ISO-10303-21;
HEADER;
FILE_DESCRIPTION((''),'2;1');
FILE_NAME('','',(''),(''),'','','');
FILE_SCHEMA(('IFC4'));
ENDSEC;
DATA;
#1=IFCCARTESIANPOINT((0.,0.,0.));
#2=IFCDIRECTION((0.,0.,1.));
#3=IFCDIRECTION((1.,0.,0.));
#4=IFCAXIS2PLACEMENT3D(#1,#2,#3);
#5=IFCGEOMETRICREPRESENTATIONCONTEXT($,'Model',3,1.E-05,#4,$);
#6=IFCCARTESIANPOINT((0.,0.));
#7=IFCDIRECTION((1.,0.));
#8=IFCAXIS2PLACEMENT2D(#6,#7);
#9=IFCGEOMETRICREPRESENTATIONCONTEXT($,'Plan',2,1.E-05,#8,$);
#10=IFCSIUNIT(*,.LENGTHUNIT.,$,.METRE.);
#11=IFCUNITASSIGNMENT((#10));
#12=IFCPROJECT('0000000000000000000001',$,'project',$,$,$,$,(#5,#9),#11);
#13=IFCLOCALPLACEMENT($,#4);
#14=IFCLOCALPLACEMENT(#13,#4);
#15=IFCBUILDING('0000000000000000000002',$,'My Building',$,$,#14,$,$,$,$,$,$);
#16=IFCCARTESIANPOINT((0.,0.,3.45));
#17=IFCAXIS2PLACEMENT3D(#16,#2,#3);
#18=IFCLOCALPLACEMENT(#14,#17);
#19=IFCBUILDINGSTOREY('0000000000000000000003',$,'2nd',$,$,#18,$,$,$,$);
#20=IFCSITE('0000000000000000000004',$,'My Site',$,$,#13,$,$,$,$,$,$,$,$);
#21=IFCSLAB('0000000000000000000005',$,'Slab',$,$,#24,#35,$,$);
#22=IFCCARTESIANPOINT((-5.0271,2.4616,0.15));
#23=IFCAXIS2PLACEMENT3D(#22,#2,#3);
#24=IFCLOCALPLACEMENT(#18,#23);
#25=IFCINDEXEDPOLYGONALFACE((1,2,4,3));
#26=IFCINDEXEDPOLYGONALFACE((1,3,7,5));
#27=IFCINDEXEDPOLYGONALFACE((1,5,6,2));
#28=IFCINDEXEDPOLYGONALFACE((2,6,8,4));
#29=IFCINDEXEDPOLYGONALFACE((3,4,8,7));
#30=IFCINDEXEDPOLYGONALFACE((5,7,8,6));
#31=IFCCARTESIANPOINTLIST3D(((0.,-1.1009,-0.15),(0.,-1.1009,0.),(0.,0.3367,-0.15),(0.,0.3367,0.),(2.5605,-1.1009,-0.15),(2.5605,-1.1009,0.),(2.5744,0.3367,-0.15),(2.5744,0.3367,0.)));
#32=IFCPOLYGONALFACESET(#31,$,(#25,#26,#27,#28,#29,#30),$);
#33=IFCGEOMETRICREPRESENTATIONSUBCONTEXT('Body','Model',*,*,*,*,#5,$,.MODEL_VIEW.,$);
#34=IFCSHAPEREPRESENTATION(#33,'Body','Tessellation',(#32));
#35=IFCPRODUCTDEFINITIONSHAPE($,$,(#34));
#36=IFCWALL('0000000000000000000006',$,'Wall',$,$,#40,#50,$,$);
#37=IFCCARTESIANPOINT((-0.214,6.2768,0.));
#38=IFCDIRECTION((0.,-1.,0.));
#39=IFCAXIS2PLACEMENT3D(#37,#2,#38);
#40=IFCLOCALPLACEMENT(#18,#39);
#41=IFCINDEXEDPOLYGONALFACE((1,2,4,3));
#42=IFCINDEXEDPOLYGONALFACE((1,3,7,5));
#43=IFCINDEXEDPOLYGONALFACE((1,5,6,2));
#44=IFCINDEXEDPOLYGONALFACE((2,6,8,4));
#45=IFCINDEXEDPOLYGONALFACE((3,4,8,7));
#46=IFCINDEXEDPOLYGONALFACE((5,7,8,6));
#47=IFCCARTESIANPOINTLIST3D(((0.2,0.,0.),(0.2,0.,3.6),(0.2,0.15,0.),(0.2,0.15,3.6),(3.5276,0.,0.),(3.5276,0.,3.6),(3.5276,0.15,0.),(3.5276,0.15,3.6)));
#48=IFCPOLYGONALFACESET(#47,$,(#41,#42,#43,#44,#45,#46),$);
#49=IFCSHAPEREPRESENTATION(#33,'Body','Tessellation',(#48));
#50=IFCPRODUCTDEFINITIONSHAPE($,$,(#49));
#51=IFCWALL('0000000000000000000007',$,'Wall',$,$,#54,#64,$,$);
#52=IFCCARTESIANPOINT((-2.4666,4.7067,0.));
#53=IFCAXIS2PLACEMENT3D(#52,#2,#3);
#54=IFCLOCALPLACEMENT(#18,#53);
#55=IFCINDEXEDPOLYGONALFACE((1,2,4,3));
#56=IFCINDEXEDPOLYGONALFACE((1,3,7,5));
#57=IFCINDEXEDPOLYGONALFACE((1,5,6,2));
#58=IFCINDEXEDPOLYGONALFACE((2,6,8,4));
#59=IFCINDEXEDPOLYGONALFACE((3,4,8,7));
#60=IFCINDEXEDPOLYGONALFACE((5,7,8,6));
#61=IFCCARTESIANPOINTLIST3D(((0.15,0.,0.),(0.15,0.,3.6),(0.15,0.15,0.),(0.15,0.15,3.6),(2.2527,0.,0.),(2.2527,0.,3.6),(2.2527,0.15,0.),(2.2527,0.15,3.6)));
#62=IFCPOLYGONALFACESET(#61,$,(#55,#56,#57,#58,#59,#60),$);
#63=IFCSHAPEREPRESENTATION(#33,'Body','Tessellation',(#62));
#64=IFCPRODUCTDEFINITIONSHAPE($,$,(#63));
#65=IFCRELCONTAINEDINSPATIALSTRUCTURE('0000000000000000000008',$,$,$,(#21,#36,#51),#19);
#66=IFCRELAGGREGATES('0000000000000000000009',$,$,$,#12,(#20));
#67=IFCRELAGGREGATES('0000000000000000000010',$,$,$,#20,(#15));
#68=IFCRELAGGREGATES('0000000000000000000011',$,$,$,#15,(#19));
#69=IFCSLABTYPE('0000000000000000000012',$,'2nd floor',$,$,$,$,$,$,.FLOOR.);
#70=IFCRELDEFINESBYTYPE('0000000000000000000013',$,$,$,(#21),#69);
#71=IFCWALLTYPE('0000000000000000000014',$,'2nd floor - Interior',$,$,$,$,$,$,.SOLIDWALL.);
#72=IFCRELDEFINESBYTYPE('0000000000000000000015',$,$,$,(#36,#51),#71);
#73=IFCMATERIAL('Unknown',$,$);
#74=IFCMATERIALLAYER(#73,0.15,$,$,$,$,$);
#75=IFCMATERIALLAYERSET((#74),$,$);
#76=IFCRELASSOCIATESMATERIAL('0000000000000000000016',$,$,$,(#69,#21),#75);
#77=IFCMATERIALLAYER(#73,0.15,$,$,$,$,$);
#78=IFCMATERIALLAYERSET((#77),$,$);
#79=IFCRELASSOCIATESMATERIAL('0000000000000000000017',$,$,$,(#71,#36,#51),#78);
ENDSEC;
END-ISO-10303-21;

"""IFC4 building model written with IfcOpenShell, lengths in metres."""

from ifc_helpers import new_model, si_unit, frame, origin_with_axes, origin_2d_with_axis, place, context, subcontext, project, spatial, line, indexed_curve, outline, extrude, material, layer, layer_set, layer_usage, type_object, element, save


model = new_model("IFC4")

# Units and contexts
model_context = context("Model", 3, precision=1e-05, world=origin_with_axes())
plan_context = context("Plan", 2, precision=1e-05, world=origin_2d_with_axis())
body_context_1 = subcontext(model_context, "Body", "Model", "MODEL_VIEW")
ifc_project = project(units=[si_unit("LENGTHUNIT", "METRE")], contexts=[model_context, plan_context])

# Site, building, storey
site_placement = place(None, origin_with_axes())
site = spatial("IfcSite", under=ifc_project, at=site_placement, Name="My Site")
building_placement = place(site_placement, origin_with_axes())
building = spatial("IfcBuilding", under=site, at=building_placement, Name="My Building")
storey_placement = place(building_placement, frame((0.0, 0.0, 3.45), z_axis=(0.0, 0.0, 1.0), x_axis=(1.0, 0.0, 0.0)))
storey = spatial("IfcBuildingStorey", under=building, at=storey_placement, Name="2nd")

# Shared definitions
ifc_material = material(Name="Unknown")

# Slab
ifc_layer_1 = layer(ifc_material, 0.15)
ifc_layer_set_1 = layer_set([ifc_layer_1])
slab_type = type_object("IfcSlabType", Name="2nd floor", PredefinedType="FLOOR", material=ifc_layer_set_1)
ifc_layer_usage_1 = layer_usage(ifc_layer_set_1, "AXIS3", "POSITIVE", -0.15)
slab_1_placement = place(storey_placement, frame((-5.0271, 2.4616, 0.15), z_axis=(0.0, 0.0, 1.0), x_axis=(1.0, 0.0, 0.0)))
element("IfcSlab", 1, at=slab_1_placement, inside=storey, type_object=slab_type, material=ifc_layer_usage_1, Name="Slab", context=body_context_1, shape_type="SweptSolid", body=[
    extrude(outline(indexed_curve([(0.0, 0.3367), (0.0, -1.1009), (2.5605, -1.1009), (2.5744, 0.3367), (0.0, 0.3367)])), frame((0.0, 0.0, -0.15), z_axis=(0.0, 0.0, 1.0), x_axis=(1.0, 0.0, 0.0)), (0.0, 0.0, 1.0), 0.15),
])

# Shared definitions
ifc_layer_2 = layer(ifc_material, 0.15)
ifc_layer_set_2 = layer_set([ifc_layer_2])
wall_type_1 = type_object("IfcWallType", Name="2nd floor - Interior", PredefinedType="SOLIDWALL", material=ifc_layer_set_2)

# Walls
ifc_layer_usage_2 = layer_usage(ifc_layer_set_2, "AXIS2", "POSITIVE", 0.0)
wall_1_placement = place(storey_placement, frame((-0.214, 6.2768, 0.0), z_axis=(0.0, 0.0, 1.0), x_axis=(0.0, -1.0, 0.0)))
element("IfcWall", 2, at=wall_1_placement, inside=storey, type_object=wall_type_1, material=ifc_layer_usage_2, Name="Wall", context=body_context_1, shape_type="SweptSolid", body=[
    extrude(outline(indexed_curve([(0.2, 0.0), (0.2, 0.15), (3.5276, 0.15), (3.5276, 0.0)], segments=[line(1, 2, 3, 4, 1)])), origin_with_axes(), (0.0, 0.0, 1.0), 3.6),
])
ifc_layer_usage_3 = layer_usage(ifc_layer_set_2, "AXIS2", "POSITIVE", 0.0)
wall_2_placement = place(storey_placement, frame((-2.4666, 4.7067, 0.0), z_axis=(0.0, 0.0, 1.0), x_axis=(1.0, 0.0, 0.0)))
element("IfcWall", 3, at=wall_2_placement, inside=storey, type_object=wall_type_1, material=ifc_layer_usage_3, Name="Wall", context=body_context_1, shape_type="SweptSolid", body=[
    extrude(outline(indexed_curve([(0.15, 0.0), (0.15, 0.15), (2.2527, 0.15), (2.2527, 0.0)], segments=[line(1, 2, 3, 4, 1)])), origin_with_axes(), (0.0, 0.0, 1.0), 3.6),
])

save(model, "model.ifc")
